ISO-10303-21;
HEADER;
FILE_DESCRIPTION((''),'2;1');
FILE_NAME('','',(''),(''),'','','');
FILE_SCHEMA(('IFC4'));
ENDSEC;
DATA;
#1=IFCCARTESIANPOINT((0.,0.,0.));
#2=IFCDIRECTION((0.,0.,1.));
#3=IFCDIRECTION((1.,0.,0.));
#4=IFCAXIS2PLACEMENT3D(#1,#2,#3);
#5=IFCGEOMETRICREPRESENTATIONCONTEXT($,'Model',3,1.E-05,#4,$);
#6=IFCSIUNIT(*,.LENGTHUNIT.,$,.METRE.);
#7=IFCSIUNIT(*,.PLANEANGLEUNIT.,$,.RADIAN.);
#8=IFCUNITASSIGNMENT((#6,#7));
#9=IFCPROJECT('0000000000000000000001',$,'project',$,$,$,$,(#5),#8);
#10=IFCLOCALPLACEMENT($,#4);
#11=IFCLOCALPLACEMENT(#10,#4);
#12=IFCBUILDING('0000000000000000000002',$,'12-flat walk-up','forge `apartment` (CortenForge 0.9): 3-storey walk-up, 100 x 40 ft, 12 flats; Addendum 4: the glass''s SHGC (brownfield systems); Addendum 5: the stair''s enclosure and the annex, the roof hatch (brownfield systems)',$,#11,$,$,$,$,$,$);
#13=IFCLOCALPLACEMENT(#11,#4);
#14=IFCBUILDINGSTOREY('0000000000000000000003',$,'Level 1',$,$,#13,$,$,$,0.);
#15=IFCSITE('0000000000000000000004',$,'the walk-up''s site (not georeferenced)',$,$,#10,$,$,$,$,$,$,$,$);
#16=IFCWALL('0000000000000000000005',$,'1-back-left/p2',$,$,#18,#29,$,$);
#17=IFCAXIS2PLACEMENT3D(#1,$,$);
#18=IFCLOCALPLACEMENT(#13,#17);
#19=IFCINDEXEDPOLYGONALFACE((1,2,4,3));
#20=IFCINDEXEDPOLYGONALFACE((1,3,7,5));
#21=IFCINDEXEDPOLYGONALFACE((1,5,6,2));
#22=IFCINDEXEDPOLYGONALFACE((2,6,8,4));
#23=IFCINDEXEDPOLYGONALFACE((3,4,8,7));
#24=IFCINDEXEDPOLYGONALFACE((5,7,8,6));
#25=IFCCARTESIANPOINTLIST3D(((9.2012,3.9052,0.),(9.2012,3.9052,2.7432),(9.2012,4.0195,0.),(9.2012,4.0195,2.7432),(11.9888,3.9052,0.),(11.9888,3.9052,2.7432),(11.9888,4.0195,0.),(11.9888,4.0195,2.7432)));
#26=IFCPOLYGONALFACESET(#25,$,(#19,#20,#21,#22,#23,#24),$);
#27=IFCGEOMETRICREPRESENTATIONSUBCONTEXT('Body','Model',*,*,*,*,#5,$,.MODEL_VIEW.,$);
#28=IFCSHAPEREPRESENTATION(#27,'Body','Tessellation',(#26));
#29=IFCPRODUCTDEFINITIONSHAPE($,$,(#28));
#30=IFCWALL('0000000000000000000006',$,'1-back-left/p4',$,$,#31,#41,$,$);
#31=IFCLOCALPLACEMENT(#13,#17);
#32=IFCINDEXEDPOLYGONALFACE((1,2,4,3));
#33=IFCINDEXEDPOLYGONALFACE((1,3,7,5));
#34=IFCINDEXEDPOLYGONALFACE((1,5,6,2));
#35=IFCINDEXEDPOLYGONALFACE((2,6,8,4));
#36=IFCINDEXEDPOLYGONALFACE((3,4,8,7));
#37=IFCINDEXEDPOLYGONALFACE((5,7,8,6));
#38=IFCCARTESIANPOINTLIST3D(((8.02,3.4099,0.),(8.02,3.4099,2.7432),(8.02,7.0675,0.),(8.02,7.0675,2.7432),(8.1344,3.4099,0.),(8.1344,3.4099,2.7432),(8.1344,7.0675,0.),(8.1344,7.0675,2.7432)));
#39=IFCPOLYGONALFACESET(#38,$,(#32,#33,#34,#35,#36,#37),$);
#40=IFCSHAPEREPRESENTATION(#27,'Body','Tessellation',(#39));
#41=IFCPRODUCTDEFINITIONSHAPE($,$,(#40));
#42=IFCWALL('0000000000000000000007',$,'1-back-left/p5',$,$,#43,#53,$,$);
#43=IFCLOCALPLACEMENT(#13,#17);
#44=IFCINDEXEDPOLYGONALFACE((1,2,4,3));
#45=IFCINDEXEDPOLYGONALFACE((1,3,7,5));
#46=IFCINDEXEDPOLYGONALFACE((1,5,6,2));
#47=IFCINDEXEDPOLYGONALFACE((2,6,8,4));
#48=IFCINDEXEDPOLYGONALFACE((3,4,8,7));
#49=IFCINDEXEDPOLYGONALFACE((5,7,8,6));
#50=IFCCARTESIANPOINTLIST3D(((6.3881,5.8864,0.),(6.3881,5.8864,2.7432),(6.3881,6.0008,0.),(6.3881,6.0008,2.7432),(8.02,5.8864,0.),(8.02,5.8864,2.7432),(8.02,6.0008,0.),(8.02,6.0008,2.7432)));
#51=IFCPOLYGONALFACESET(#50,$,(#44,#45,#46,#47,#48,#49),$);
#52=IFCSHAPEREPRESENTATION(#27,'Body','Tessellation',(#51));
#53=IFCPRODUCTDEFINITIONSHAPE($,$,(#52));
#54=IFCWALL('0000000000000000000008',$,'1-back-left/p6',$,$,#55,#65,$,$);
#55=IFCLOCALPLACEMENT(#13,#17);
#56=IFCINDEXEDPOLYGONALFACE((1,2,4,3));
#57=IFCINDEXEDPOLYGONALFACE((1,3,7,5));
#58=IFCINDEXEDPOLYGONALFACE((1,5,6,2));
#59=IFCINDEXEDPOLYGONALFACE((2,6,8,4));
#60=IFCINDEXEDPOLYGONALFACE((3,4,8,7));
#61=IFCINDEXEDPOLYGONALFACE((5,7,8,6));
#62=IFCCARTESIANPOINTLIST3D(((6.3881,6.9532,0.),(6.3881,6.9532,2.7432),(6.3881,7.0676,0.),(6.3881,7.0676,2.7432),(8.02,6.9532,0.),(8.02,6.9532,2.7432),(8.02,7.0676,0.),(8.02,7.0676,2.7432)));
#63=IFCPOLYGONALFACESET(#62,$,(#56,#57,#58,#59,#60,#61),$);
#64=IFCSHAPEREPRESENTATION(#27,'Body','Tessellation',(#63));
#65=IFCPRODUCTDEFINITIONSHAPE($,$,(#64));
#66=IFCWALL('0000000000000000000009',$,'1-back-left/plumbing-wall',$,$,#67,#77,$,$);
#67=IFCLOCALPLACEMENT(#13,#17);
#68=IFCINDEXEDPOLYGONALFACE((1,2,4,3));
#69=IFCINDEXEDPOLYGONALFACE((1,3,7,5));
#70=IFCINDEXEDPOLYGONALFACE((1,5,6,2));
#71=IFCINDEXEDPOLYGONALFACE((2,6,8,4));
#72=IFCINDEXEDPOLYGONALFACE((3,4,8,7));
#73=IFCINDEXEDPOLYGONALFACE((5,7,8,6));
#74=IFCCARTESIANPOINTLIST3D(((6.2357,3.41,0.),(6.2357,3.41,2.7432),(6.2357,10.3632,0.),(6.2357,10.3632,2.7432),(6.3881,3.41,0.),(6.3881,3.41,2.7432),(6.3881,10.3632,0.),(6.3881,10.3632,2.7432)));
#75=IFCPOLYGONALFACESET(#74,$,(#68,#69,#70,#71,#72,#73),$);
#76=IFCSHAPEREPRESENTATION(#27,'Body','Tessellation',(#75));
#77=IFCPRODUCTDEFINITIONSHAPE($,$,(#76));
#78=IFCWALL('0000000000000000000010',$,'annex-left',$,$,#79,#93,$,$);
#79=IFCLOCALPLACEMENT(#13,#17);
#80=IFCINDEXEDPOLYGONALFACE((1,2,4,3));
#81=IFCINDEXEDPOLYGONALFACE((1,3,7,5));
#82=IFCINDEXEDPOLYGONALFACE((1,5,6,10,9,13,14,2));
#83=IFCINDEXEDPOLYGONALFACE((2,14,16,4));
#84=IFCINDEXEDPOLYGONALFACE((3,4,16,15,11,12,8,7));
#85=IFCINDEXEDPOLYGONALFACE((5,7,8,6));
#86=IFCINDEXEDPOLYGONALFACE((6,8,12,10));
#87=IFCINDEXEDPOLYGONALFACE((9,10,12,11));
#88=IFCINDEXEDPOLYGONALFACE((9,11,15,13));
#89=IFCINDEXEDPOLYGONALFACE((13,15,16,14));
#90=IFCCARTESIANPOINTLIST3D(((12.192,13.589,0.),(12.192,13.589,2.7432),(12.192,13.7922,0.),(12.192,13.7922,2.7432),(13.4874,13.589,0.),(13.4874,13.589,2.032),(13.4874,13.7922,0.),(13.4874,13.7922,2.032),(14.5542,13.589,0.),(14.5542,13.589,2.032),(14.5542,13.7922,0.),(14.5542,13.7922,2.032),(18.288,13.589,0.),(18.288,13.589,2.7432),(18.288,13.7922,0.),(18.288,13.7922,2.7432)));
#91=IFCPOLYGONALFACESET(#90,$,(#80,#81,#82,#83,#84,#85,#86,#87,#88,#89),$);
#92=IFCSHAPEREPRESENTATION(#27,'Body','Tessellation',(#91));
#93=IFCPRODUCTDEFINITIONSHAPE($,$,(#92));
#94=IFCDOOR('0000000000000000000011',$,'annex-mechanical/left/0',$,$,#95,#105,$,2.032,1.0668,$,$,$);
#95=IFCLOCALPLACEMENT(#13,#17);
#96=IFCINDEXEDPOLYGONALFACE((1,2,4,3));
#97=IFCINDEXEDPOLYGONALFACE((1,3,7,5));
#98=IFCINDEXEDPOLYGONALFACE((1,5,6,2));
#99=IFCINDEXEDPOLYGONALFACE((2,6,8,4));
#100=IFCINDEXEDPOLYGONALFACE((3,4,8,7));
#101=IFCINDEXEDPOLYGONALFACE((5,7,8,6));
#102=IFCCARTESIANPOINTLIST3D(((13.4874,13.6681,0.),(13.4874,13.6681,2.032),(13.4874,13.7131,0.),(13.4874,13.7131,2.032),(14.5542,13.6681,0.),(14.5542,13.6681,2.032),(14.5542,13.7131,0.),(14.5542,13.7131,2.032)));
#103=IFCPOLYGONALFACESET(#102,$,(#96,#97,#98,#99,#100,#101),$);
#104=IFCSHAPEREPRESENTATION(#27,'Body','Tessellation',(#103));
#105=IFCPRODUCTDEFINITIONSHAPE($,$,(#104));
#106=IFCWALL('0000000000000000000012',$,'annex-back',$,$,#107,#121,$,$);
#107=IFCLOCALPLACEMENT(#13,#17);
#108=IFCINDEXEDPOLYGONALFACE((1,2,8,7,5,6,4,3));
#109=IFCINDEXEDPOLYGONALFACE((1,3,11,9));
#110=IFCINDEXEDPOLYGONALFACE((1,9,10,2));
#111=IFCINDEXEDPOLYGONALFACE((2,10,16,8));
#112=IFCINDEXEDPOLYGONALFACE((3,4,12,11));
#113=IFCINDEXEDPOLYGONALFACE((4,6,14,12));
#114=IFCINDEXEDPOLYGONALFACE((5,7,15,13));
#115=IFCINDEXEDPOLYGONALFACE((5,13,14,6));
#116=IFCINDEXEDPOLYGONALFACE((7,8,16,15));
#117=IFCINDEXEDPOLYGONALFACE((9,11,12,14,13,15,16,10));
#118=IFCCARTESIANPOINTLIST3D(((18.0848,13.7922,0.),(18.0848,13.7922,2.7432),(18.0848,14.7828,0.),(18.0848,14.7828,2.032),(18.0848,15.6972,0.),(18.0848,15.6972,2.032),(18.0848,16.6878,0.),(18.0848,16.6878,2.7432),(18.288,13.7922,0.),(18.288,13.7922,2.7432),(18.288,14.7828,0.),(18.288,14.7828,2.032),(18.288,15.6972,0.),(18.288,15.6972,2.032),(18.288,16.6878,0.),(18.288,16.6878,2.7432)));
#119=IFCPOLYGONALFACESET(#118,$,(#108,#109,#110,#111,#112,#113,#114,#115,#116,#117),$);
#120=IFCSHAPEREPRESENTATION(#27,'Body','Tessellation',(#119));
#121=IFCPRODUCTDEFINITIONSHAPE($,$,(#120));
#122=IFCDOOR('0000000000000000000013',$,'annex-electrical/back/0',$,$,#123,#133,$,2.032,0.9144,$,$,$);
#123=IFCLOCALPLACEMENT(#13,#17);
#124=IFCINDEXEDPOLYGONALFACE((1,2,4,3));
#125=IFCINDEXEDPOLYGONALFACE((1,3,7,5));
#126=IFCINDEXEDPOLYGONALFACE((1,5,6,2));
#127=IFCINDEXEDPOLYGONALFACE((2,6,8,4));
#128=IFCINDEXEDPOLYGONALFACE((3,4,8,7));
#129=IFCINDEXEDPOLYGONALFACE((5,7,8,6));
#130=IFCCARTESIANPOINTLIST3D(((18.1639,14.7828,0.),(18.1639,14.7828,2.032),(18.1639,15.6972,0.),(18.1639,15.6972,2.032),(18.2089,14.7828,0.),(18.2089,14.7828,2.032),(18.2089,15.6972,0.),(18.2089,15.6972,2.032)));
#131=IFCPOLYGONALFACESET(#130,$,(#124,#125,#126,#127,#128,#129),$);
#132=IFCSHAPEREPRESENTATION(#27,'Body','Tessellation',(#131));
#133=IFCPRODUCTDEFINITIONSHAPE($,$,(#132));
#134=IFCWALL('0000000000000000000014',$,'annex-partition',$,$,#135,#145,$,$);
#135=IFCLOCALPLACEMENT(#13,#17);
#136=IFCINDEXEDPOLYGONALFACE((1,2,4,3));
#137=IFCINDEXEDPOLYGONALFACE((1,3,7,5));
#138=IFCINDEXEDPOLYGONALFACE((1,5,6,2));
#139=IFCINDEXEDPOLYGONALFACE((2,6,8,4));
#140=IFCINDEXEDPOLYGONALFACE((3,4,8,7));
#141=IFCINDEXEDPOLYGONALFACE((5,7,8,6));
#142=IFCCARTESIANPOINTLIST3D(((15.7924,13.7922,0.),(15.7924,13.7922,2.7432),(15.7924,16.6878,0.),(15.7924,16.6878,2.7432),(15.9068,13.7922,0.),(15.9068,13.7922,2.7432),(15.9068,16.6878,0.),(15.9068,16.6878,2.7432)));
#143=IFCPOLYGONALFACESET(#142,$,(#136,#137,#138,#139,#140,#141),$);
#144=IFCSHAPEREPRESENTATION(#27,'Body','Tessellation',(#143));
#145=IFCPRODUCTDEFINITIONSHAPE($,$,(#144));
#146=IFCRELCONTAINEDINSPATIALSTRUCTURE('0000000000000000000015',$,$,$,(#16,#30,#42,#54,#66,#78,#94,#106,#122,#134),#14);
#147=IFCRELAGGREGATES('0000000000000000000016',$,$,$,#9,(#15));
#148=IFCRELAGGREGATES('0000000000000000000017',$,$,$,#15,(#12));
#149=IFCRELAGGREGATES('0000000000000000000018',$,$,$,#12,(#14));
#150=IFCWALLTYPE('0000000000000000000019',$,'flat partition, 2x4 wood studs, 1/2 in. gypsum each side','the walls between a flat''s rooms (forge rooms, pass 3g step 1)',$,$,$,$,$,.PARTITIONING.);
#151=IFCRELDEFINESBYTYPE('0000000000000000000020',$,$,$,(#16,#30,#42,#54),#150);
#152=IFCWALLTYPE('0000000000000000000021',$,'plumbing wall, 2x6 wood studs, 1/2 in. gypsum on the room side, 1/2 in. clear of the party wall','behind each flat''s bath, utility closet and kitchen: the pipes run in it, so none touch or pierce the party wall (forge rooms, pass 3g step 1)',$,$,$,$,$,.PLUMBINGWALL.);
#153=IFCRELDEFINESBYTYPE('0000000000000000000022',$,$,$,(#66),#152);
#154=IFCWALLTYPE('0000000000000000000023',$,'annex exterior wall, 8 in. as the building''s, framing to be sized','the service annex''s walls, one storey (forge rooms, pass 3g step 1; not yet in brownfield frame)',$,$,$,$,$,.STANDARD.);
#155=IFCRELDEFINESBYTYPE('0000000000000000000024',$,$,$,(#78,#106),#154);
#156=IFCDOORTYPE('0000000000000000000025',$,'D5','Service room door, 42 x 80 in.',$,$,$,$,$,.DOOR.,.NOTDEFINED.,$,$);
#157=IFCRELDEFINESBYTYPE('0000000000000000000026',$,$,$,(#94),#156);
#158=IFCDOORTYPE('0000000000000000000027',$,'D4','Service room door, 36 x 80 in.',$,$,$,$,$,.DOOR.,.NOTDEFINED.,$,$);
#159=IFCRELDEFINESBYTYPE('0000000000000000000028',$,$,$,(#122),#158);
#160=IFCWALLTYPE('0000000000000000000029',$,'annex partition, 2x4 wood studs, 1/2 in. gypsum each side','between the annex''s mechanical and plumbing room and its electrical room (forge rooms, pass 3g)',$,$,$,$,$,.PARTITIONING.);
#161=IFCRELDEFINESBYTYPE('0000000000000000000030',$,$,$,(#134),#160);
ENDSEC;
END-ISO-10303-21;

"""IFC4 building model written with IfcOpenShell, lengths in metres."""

from ifc_helpers import new_model, si_unit, frame, frame_2d, origin, origin_with_axes, place, context, subcontext, project, spatial, rectangle, extrude, type_object, element, fill, save


model = new_model("IFC4")

# Units and contexts
model_context = context("Model", 3, precision=1e-05, world=origin_with_axes())
body_context = subcontext(model_context, "Body", "Model", "MODEL_VIEW")
ifc_project = project(units=[si_unit("LENGTHUNIT", "METRE"), si_unit("PLANEANGLEUNIT", "RADIAN")], contexts=[model_context])

# Site, building, storey
site_placement = place(None, origin_with_axes())
site = spatial("IfcSite", under=ifc_project, at=site_placement, Name="the walk-up's site (not georeferenced)")
building_placement = place(site_placement, origin_with_axes())
building = spatial("IfcBuilding", under=site, at=building_placement, Name="12-flat walk-up", Description="forge `apartment` (CortenForge 0.9): 3-storey walk-up, 100 x 40 ft, 12 flats; Addendum 4: the glass's SHGC (brownfield systems); Addendum 5: the stair's enclosure and the annex, the roof hatch (brownfield systems)")
storey_placement = place(building_placement, origin_with_axes())
storey = spatial("IfcBuildingStorey", under=building, at=storey_placement, Name="Level 1", Elevation=0.0)

# Walls
wall_type_1 = type_object("IfcWallType", Name="flat partition, 2x4 wood studs, 1/2 in. gypsum each side", Description="the walls between a flat's rooms (forge rooms, pass 3g step 1)", PredefinedType="PARTITIONING")
wall_1_placement = place(storey_placement, frame((9.2012, 3.9052, 0.0), z_axis=(0.0, 0.0, 1.0), x_axis=(1.0, 0.0, 0.0)))
element("IfcWall", 1, at=wall_1_placement, inside=storey, type_object=wall_type_1, Name="1-back-left/p2", context=body_context, shape_type="SweptSolid", body=[
    extrude(rectangle(XDim=2.7876, YDim=0.1143, at=frame_2d((1.3938, 0.0571))), origin(), (0.0, 0.0, 1.0), 2.7432),
])
wall_2_placement = place(storey_placement, frame((8.02, 3.4099, 0.0), z_axis=(0.0, 0.0, 1.0), x_axis=(1.0, 0.0, 0.0)))
element("IfcWall", 2, at=wall_2_placement, inside=storey, type_object=wall_type_1, Name="1-back-left/p4", context=body_context, shape_type="SweptSolid", body=[
    extrude(rectangle(XDim=0.1143, YDim=3.6576, at=frame_2d((0.0572, 1.8288))), origin(), (0.0, 0.0, 1.0), 2.7432),
])
for number, where, z_axis, x_axis, name in (
    (3, (6.3881, 5.8864, 0.0), (0.0, 0.0, 1.0), (1.0, 0.0, 0.0), "1-back-left/p5"),
    (4, (6.3881, 6.9532, 0.0), (0.0, 0.0, 1.0), (1.0, 0.0, 0.0), "1-back-left/p6"),
):
    element("IfcWall", number, at=place(storey_placement, frame(where, z_axis=z_axis, x_axis=x_axis)), inside=storey, type_object=wall_type_1, Name=name, context=body_context, shape_type="SweptSolid", body=[
        extrude(rectangle(XDim=1.6319, YDim=0.1143, at=frame_2d((0.816, 0.0572))), origin(), (0.0, 0.0, 1.0), 2.7432),
    ])
wall_type_2 = type_object("IfcWallType", Name="plumbing wall, 2x6 wood studs, 1/2 in. gypsum on the room side, 1/2 in. clear of the party wall", Description="behind each flat's bath, utility closet and kitchen: the pipes run in it, so none touch or pierce the party wall (forge rooms, pass 3g step 1)", PredefinedType="PLUMBINGWALL")
wall_3_placement = place(storey_placement, frame((6.2357, 3.41, 0.0), z_axis=(0.0, 0.0, 1.0), x_axis=(1.0, 0.0, 0.0)))
element("IfcWall", 5, at=wall_3_placement, inside=storey, type_object=wall_type_2, Name="1-back-left/plumbing-wall", context=body_context, shape_type="SweptSolid", body=[
    extrude(rectangle(XDim=0.1524, YDim=6.9533, at=frame_2d((0.0762, 3.4766))), origin(), (0.0, 0.0, 1.0), 2.7432),
])

# Walls, openings, doors
wall_type_3 = type_object("IfcWallType", Name="annex exterior wall, 8 in. as the building's, framing to be sized", Description="the service annex's walls, one storey (forge rooms, pass 3g step 1; not yet in brownfield frame)", PredefinedType="STANDARD")
wall_4_placement = place(storey_placement, frame((12.192, 13.589, 0.0), z_axis=(0.0, 0.0, 1.0), x_axis=(1.0, 0.0, 0.0)))
wall_4 = element("IfcWall", 6, at=wall_4_placement, inside=storey, type_object=wall_type_3, Name="annex-left", context=body_context, shape_type="SweptSolid", body=[
    extrude(rectangle(XDim=6.096, YDim=0.2032, at=frame_2d((3.048, 0.1016))), origin(), (0.0, 0.0, 1.0), 2.7432),
])
opening_1_placement = place(wall_4_placement, frame((1.2954, 0.0, 0.0), z_axis=(0.0, 0.0, 1.0), x_axis=(1.0, 0.0, 0.0)))
opening_1 = element("IfcOpeningElement", 7, at=opening_1_placement, cuts=wall_4, PredefinedType="OPENING", context=body_context, shape_type="SweptSolid", body=[
    extrude(rectangle(XDim=1.0668, YDim=0.2032, at=frame_2d((0.5334, 0.1016))), origin(), (0.0, 0.0, 1.0), 2.032),
])
door_type_1 = type_object("IfcDoorType", Name="D5", Description="Service room door, 42 x 80 in.", OperationType="NOTDEFINED", PredefinedType="DOOR")
door_1_placement = place(opening_1_placement, frame((0.0, 0.0791, 0.0), z_axis=(0.0, 0.0, 1.0), x_axis=(1.0, 0.0, 0.0)))
door_1 = element("IfcDoor", 8, at=door_1_placement, inside=storey, type_object=door_type_1, Name="annex-mechanical/left/0", OverallHeight=2.032, OverallWidth=1.0668, context=body_context, shape_type="SweptSolid", body=[
    extrude(rectangle(XDim=1.0668, YDim=0.045, at=frame_2d((0.5334, 0.0225))), origin(), (0.0, 0.0, 1.0), 2.032),
])
fill(opening_1, door_1)
wall_5_placement = place(storey_placement, frame((18.0848, 13.7922, 0.0), z_axis=(0.0, 0.0, 1.0), x_axis=(1.0, 0.0, 0.0)))
wall_5 = element("IfcWall", 9, at=wall_5_placement, inside=storey, type_object=wall_type_3, Name="annex-back", context=body_context, shape_type="SweptSolid", body=[
    extrude(rectangle(XDim=0.2032, YDim=2.8956, at=frame_2d((0.1016, 1.4478))), origin(), (0.0, 0.0, 1.0), 2.7432),
])
opening_2_placement = place(wall_5_placement, frame((0.2032, 0.9906, 0.0), z_axis=(0.0, 0.0, 1.0), x_axis=(0.0, 1.0, 0.0)))
opening_2 = element("IfcOpeningElement", 10, at=opening_2_placement, cuts=wall_5, PredefinedType="OPENING", context=body_context, shape_type="SweptSolid", body=[
    extrude(rectangle(XDim=0.9144, YDim=0.2032, at=frame_2d((0.4572, 0.1016))), origin(), (0.0, 0.0, 1.0), 2.032),
])
door_type_2 = type_object("IfcDoorType", Name="D4", Description="Service room door, 36 x 80 in.", OperationType="NOTDEFINED", PredefinedType="DOOR")
door_2_placement = place(opening_2_placement, frame((0.0, 0.0791, 0.0), z_axis=(0.0, 0.0, 1.0), x_axis=(1.0, 0.0, 0.0)))
door_2 = element("IfcDoor", 11, at=door_2_placement, inside=storey, type_object=door_type_2, Name="annex-electrical/back/0", OverallHeight=2.032, OverallWidth=0.9144, context=body_context, shape_type="SweptSolid", body=[
    extrude(rectangle(XDim=0.9144, YDim=0.045, at=frame_2d((0.4572, 0.0225))), origin(), (0.0, 0.0, 1.0), 2.032),
])
fill(opening_2, door_2)

# Wall
wall_type_4 = type_object("IfcWallType", Name="annex partition, 2x4 wood studs, 1/2 in. gypsum each side", Description="between the annex's mechanical and plumbing room and its electrical room (forge rooms, pass 3g)", PredefinedType="PARTITIONING")
wall_6_placement = place(storey_placement, frame((15.7925, 13.7922, 0.0), z_axis=(0.0, 0.0, 1.0), x_axis=(1.0, 0.0, 0.0)))
element("IfcWall", 12, at=wall_6_placement, inside=storey, type_object=wall_type_4, Name="annex-partition", context=body_context, shape_type="SweptSolid", body=[
    extrude(rectangle(XDim=0.1143, YDim=2.8956, at=frame_2d((0.0572, 1.4478))), origin(), (0.0, 0.0, 1.0), 2.7432),
])

save(model, "model.ifc")
